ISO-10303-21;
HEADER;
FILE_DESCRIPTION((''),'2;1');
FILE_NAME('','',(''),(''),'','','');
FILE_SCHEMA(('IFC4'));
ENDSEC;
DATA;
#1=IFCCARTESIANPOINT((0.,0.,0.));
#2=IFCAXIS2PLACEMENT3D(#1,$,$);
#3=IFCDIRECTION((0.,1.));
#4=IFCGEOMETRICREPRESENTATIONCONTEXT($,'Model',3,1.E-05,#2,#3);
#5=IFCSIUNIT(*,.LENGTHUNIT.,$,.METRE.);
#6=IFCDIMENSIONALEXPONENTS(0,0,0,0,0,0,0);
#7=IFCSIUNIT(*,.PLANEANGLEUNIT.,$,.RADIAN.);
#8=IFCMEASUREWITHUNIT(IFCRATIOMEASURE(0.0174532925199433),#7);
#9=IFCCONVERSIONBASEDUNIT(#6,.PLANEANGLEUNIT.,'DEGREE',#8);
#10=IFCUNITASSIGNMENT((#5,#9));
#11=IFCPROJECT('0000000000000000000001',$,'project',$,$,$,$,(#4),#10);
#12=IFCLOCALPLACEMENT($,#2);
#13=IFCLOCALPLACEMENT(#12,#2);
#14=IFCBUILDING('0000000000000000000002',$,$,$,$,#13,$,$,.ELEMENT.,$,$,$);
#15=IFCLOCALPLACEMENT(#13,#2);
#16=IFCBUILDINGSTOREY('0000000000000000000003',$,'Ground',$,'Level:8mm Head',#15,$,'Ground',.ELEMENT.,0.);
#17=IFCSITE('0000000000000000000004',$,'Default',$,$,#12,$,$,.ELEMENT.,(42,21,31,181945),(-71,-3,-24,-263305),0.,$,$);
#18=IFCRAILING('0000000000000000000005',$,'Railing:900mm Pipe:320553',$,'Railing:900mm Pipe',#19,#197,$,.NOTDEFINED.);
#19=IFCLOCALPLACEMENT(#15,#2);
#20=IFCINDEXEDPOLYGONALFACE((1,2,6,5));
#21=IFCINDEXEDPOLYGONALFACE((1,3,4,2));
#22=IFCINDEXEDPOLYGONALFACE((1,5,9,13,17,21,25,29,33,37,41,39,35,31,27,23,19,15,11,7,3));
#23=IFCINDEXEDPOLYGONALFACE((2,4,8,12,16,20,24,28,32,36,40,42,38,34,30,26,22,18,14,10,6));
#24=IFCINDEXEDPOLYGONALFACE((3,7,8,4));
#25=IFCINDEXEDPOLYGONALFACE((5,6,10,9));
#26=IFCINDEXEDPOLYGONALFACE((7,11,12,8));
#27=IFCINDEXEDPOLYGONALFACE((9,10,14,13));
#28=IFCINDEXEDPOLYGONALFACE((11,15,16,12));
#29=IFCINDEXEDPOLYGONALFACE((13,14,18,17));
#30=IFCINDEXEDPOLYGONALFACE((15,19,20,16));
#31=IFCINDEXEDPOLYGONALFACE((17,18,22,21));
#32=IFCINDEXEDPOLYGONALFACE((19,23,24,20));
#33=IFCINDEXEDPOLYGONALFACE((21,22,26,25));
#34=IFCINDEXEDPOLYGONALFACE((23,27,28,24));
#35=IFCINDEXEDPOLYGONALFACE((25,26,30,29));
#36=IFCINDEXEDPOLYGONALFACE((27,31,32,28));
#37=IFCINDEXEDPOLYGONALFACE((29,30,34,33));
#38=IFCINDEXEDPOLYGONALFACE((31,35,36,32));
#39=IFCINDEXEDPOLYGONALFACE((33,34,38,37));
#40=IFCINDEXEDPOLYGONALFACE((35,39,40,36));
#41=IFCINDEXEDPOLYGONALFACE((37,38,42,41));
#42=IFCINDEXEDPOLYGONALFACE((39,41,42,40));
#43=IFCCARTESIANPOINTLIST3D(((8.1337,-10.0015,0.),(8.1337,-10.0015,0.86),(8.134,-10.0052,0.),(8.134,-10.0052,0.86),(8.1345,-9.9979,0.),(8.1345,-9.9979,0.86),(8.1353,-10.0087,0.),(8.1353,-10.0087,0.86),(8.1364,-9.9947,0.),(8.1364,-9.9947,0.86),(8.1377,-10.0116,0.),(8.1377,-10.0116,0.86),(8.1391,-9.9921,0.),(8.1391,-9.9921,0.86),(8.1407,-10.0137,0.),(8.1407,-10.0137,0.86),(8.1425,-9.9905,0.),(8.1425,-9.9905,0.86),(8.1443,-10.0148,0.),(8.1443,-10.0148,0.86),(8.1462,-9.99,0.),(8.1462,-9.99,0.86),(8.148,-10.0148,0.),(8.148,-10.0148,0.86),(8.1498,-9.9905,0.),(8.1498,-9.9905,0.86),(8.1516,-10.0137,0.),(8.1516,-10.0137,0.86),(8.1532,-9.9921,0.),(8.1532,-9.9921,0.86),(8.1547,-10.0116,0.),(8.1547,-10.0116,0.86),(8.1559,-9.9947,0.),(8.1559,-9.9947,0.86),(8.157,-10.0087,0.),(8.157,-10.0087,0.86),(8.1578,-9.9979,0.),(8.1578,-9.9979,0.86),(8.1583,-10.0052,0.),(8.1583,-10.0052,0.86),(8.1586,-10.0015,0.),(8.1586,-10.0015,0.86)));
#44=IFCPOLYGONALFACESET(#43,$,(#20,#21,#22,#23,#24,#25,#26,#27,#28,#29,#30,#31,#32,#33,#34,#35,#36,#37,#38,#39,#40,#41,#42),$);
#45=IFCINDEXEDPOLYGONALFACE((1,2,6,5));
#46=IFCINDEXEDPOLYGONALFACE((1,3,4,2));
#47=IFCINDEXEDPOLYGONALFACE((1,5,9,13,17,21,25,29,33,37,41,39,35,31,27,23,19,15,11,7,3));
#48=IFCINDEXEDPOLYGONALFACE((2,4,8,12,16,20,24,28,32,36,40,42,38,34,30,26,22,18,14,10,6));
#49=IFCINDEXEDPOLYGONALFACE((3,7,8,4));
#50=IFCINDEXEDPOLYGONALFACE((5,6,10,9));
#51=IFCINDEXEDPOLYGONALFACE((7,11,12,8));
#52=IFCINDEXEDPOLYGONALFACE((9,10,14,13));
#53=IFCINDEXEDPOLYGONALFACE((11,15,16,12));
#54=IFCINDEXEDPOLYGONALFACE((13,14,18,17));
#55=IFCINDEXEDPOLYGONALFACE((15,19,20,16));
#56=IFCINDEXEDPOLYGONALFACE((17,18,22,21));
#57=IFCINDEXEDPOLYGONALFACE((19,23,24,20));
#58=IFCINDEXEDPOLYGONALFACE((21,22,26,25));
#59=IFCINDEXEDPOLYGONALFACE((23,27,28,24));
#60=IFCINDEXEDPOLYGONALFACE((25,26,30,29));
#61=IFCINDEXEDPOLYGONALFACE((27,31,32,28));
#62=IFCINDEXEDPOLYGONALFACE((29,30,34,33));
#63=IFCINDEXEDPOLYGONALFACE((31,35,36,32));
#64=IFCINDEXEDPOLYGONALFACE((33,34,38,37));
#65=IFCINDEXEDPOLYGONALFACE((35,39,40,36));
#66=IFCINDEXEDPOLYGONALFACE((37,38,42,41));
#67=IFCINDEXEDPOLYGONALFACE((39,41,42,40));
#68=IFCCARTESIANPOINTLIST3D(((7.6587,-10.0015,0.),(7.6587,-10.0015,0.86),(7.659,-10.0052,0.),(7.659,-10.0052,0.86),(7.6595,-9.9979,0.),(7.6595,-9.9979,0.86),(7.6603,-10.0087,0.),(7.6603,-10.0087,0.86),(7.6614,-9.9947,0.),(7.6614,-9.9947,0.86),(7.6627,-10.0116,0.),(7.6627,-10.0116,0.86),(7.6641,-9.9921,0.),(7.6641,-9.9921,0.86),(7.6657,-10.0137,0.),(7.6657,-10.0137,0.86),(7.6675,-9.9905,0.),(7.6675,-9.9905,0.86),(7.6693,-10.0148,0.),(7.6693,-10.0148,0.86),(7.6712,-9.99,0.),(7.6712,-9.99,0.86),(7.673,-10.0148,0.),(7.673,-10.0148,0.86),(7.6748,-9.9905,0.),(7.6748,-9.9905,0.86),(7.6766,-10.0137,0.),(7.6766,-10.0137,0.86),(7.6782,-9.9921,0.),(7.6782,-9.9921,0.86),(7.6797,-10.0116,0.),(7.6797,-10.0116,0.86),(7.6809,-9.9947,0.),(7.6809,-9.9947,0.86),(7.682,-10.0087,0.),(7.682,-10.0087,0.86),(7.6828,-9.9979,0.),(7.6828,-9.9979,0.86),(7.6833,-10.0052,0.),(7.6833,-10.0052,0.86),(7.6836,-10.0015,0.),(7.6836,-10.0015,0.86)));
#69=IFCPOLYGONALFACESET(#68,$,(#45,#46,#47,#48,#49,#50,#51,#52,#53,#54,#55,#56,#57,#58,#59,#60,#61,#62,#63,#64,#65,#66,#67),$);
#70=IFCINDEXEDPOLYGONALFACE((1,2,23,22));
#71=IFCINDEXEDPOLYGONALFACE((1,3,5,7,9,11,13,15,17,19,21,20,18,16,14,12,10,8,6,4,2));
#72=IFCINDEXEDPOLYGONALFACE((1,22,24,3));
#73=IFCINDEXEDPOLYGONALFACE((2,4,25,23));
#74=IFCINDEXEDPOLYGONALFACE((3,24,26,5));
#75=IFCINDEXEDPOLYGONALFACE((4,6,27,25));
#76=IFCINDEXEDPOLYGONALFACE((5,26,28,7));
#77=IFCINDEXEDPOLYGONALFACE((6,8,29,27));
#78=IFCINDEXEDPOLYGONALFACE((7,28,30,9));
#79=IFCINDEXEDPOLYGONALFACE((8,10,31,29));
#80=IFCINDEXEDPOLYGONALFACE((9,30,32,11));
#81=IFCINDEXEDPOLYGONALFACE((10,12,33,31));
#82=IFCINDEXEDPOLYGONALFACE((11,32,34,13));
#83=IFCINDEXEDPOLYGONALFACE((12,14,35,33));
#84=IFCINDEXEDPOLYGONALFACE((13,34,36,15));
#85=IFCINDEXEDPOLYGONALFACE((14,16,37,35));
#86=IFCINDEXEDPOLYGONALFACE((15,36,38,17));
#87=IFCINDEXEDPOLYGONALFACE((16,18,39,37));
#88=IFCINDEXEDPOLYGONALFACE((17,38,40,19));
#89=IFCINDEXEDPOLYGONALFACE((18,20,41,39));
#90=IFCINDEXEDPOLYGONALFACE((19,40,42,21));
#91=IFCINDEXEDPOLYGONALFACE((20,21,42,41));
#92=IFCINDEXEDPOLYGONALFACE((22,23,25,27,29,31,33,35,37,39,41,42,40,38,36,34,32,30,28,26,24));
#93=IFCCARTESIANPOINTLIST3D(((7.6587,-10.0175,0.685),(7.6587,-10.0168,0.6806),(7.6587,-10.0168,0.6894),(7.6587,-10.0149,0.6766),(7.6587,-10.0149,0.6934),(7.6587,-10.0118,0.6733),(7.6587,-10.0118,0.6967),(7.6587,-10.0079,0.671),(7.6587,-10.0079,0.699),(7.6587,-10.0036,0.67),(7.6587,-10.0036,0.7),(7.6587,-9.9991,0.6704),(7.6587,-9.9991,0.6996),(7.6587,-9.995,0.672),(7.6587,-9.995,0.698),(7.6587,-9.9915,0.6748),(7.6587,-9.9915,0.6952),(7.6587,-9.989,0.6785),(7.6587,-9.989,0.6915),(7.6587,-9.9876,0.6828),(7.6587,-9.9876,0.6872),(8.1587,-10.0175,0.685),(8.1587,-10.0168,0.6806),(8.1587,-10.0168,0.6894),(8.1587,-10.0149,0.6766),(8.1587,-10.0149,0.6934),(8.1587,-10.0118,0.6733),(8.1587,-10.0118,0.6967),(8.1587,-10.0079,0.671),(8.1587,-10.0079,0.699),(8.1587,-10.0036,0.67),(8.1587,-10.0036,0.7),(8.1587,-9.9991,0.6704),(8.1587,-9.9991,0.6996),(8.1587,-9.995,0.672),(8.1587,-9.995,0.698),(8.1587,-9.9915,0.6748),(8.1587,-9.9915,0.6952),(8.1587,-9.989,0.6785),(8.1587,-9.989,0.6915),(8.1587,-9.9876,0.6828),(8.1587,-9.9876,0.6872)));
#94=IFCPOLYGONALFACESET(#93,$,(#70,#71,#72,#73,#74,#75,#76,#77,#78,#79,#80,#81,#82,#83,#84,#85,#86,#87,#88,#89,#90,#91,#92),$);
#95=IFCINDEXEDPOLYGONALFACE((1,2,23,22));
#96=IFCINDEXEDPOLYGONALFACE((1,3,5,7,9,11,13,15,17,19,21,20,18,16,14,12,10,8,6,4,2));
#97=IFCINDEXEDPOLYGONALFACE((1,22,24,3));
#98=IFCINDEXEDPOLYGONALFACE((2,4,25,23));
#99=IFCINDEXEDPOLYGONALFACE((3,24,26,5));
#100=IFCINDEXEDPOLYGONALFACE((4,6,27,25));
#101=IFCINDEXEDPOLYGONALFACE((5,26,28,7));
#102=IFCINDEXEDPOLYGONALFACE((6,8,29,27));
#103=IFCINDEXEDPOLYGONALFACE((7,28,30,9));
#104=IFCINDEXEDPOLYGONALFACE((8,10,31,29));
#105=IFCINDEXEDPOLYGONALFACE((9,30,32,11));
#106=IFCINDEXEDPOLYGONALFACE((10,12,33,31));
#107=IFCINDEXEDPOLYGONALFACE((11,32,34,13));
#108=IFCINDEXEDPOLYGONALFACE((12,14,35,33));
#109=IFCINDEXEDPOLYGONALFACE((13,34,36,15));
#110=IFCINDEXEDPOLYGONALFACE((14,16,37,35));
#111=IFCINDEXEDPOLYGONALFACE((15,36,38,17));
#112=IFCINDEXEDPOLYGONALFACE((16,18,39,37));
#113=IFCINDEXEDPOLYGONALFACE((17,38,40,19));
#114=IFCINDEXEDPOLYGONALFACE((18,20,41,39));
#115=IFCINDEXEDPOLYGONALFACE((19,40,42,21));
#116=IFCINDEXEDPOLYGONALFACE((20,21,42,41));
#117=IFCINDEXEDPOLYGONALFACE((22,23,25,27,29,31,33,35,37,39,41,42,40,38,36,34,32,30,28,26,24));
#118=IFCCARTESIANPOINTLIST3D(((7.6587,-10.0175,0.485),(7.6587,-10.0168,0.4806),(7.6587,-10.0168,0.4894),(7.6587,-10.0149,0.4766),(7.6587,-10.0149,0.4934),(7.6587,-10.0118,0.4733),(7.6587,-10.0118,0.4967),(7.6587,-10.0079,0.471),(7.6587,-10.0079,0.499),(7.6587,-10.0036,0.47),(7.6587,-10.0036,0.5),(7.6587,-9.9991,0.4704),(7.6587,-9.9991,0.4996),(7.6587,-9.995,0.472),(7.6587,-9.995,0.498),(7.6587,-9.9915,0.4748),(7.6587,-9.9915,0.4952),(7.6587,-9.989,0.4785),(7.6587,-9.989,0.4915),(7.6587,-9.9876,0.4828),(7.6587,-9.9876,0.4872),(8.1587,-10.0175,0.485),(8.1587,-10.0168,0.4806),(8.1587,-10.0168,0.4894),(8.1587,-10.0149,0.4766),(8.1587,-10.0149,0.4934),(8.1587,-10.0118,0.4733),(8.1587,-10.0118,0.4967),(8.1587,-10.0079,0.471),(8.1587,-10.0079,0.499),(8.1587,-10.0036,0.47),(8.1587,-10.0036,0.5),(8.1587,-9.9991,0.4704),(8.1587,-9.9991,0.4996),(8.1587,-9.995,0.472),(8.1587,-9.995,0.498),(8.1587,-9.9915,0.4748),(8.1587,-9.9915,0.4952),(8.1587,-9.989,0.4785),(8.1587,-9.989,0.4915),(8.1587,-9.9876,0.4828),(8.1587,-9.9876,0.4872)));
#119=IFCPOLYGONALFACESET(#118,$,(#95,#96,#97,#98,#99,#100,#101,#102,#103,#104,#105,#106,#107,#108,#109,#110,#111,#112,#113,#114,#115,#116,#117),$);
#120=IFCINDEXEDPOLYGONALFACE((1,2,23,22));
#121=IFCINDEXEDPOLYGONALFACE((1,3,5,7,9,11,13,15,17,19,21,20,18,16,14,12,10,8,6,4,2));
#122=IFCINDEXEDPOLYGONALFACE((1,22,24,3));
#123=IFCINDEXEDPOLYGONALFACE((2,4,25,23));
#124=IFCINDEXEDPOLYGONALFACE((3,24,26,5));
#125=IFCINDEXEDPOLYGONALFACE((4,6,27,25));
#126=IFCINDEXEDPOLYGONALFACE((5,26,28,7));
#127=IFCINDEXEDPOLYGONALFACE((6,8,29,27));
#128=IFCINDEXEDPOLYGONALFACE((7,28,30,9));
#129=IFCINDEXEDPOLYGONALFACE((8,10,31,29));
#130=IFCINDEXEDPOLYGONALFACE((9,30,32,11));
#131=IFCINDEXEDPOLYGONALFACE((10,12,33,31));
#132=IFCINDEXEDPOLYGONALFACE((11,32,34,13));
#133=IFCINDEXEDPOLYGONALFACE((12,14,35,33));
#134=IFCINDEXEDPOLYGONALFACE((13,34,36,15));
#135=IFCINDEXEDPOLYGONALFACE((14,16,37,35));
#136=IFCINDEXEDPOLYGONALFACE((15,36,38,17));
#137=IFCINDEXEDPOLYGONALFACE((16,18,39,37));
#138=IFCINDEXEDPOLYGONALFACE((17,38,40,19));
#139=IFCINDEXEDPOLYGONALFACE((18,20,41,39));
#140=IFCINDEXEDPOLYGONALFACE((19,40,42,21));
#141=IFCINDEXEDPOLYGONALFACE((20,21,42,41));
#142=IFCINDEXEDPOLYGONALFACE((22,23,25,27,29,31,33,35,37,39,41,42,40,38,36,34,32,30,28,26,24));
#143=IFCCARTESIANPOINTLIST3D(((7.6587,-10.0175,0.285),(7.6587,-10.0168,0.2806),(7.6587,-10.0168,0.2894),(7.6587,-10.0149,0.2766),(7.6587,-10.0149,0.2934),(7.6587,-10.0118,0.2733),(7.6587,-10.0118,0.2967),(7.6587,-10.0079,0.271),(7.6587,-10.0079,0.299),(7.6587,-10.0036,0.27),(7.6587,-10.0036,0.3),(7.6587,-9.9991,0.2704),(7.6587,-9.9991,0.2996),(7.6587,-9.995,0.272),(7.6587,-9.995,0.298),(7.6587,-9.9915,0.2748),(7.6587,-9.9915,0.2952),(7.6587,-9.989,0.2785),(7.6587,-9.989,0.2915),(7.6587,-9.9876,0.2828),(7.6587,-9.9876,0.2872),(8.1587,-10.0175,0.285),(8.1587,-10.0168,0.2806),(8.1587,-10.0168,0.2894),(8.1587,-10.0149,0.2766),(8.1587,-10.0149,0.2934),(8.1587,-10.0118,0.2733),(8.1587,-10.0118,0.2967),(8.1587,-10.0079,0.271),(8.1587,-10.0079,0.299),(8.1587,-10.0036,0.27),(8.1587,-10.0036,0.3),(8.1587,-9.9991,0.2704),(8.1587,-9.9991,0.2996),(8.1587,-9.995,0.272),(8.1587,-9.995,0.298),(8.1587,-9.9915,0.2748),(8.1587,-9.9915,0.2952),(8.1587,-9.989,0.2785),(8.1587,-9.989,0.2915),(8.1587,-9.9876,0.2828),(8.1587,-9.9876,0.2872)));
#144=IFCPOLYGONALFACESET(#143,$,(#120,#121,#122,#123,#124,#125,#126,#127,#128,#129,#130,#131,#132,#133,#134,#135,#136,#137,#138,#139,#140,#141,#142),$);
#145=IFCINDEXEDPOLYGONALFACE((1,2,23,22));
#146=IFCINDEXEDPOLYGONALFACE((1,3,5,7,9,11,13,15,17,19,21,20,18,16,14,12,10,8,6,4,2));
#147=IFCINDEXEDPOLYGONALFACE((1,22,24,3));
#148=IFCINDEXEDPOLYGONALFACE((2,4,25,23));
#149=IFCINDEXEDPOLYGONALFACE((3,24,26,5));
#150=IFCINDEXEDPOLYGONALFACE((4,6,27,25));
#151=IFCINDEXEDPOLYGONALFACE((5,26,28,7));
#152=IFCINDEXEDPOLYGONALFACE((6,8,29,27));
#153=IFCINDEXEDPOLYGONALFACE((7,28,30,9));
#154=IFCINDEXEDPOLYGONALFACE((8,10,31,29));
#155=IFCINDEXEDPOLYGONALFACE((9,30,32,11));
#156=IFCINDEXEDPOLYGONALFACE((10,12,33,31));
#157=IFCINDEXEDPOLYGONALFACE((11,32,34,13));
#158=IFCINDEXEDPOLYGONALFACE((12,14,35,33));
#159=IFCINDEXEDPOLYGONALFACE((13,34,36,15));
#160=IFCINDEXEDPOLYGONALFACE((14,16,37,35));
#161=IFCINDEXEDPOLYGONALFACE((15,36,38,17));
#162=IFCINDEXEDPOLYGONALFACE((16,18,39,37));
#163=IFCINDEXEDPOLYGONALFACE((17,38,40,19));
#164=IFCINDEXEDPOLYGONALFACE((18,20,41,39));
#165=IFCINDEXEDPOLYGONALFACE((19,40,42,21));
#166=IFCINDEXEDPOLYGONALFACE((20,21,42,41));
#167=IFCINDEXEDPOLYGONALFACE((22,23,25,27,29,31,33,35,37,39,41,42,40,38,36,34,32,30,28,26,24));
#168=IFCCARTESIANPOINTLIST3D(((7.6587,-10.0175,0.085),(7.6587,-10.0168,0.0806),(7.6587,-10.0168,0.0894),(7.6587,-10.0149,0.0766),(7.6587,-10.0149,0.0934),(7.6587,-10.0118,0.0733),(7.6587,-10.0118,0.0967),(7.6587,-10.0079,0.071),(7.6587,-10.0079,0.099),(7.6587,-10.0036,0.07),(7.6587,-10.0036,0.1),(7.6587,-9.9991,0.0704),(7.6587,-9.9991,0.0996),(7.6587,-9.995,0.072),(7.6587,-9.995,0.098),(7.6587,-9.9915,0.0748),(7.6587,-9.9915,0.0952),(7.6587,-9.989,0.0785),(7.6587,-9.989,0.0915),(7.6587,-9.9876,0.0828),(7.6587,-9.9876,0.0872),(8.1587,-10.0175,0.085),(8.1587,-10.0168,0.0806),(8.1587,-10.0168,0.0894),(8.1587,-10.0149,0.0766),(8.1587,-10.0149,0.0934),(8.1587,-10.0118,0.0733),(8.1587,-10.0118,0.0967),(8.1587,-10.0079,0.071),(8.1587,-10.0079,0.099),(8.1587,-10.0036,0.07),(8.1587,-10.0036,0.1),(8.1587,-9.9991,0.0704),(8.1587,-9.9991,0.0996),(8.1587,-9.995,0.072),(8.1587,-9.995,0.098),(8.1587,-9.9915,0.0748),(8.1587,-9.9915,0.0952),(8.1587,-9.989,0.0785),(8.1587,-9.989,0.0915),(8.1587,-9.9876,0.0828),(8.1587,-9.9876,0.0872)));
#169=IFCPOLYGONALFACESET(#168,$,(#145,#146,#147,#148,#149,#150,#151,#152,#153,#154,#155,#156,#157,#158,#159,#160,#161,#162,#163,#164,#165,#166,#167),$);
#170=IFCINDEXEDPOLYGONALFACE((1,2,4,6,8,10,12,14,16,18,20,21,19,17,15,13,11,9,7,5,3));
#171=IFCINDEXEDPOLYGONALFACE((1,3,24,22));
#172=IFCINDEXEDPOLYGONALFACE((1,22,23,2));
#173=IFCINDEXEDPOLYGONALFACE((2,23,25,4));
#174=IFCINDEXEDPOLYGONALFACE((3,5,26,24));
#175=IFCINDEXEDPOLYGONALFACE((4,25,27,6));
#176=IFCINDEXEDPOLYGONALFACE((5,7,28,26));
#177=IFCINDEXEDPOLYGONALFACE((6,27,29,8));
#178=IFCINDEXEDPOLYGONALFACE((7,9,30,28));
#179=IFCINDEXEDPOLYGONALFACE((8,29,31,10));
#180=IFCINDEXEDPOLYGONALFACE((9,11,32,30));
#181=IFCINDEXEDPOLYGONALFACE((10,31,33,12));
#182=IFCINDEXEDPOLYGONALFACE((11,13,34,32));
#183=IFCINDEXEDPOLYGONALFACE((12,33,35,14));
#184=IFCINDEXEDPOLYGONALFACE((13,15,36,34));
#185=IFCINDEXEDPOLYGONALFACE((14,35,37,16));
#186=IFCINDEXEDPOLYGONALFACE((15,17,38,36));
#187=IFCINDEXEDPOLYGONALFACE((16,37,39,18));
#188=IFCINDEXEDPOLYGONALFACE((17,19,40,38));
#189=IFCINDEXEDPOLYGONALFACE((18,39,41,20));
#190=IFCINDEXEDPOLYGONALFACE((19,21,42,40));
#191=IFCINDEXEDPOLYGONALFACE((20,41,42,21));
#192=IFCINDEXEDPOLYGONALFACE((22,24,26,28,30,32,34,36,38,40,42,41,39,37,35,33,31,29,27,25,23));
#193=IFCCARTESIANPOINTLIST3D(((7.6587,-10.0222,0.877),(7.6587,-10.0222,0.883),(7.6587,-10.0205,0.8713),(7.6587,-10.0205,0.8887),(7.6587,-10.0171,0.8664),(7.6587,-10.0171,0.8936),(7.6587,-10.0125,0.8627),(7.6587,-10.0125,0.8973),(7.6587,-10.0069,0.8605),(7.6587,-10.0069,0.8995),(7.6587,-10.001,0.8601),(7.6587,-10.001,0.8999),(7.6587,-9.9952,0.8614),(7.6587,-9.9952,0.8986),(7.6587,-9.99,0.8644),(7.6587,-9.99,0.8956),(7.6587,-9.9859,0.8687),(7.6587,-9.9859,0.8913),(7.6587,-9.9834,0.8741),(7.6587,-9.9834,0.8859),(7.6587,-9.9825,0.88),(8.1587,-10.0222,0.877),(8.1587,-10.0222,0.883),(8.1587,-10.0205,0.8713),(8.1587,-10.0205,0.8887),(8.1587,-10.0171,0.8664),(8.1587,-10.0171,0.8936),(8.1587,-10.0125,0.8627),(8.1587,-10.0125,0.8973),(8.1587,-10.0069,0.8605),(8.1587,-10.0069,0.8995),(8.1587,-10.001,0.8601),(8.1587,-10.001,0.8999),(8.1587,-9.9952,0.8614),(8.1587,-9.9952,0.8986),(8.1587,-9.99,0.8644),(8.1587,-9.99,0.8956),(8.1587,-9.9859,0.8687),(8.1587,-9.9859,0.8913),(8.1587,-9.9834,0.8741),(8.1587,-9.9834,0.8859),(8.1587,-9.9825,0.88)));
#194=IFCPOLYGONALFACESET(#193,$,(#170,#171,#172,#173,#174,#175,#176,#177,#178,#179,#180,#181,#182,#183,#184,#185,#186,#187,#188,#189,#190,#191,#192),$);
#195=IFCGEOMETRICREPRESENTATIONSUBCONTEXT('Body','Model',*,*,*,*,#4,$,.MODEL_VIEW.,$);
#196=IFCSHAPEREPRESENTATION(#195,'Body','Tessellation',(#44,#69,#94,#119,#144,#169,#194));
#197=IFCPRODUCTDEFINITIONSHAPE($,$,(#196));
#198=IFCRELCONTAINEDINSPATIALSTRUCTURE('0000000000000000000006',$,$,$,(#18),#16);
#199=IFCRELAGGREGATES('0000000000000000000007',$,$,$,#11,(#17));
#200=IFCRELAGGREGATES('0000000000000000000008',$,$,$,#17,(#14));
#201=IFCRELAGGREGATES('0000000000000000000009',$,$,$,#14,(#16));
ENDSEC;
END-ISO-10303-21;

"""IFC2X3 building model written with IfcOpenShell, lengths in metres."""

from ifc_helpers import new_model, entity, si_unit, converted_unit, direction, frame, frame_2d, origin, origin_2d_with_axis, place, context, subcontext, project, spatial, circle, extrude, element, save


model = new_model("IFC2X3")

# Units and contexts
model_context = context("Model", 3, precision=1e-05, world=origin(), true_north=direction((0.0, 1.0)))
body_context = subcontext(model_context, "Body", "Model", "MODEL_VIEW")
ifc_project = project(units=[si_unit("LENGTHUNIT", "METRE"), converted_unit("PLANEANGLEUNIT", "DEGREE", entity("IfcRatioMeasure", 0.0174532925199433), si_unit("PLANEANGLEUNIT", "RADIAN"), dimensions=[0, 0, 0, 0, 0, 0, 0])], contexts=[model_context])

# Site, building, storey
site_placement = place(None, origin())
site = spatial("IfcSite", under=ifc_project, at=site_placement, Name="Default", CompositionType="ELEMENT", RefLatitude=(42, 21, 31, 181945), RefLongitude=(-71, -3, -24, -263305), RefElevation=0.0)
building_placement = place(site_placement, origin())
building = spatial("IfcBuilding", under=site, at=building_placement, CompositionType="ELEMENT")
storey_placement = place(building_placement, origin())
storey = spatial("IfcBuildingStorey", under=building, at=storey_placement, Name="Ground", ObjectType="Level:8mm Head", LongName="Ground", CompositionType="ELEMENT", Elevation=0.0)

# Railing
railing_placement = place(storey_placement, origin())
element("IfcRailing", 1, at=railing_placement, inside=storey, Name="Railing:900mm Pipe:320553", ObjectType="Railing:900mm Pipe", PredefinedType="NOTDEFINED", context=body_context, shape_type="SweptSolid", body=[
    extrude(circle(Radius=0.0125, at=origin_2d_with_axis()), frame((8.1462, -10.0025, 0.0), z_axis=(0.0, 0.0, 1.0), x_axis=(0.0, 1.0, 0.0)), (0.0, 0.0, 1.0), 0.86),
    extrude(circle(Radius=0.0125, at=origin_2d_with_axis()), frame((7.6712, -10.0025, 0.0), z_axis=(0.0, 0.0, 1.0), x_axis=(0.0, 1.0, 0.0)), (0.0, 0.0, 1.0), 0.86),
    extrude(circle(Radius=0.015, at=origin_2d_with_axis()), frame((7.6587, -10.0025, 0.685), z_axis=(1.0, 0.0, 0.0), x_axis=(0.0, -1.0, 0.0)), (0.0, 0.0, 1.0), 0.5),
    extrude(circle(Radius=0.015, at=origin_2d_with_axis()), frame((7.6587, -10.0025, 0.485), z_axis=(1.0, 0.0, 0.0), x_axis=(0.0, -1.0, 0.0)), (0.0, 0.0, 1.0), 0.5),
    extrude(circle(Radius=0.015, at=origin_2d_with_axis()), frame((7.6587, -10.0025, 0.285), z_axis=(1.0, 0.0, 0.0), x_axis=(0.0, -1.0, 0.0)), (0.0, 0.0, 1.0), 0.5),
    extrude(circle(Radius=0.015, at=frame_2d((0.0, 0.0), x_axis=(1.0, 0.0))), frame((7.6587, -10.0025, 0.085), z_axis=(1.0, 0.0, 0.0), x_axis=(0.0, -1.0, 0.0)), (0.0, 0.0, 1.0), 0.5),
    extrude(circle(Radius=0.02, at=origin_2d_with_axis()), frame((7.6587, -10.0025, 0.88), z_axis=(1.0, 0.0, 0.0), x_axis=(0.0, 1.0, 0.0)), (0.0, 0.0, 1.0), 0.5),
])

save(model, "model.ifc")
